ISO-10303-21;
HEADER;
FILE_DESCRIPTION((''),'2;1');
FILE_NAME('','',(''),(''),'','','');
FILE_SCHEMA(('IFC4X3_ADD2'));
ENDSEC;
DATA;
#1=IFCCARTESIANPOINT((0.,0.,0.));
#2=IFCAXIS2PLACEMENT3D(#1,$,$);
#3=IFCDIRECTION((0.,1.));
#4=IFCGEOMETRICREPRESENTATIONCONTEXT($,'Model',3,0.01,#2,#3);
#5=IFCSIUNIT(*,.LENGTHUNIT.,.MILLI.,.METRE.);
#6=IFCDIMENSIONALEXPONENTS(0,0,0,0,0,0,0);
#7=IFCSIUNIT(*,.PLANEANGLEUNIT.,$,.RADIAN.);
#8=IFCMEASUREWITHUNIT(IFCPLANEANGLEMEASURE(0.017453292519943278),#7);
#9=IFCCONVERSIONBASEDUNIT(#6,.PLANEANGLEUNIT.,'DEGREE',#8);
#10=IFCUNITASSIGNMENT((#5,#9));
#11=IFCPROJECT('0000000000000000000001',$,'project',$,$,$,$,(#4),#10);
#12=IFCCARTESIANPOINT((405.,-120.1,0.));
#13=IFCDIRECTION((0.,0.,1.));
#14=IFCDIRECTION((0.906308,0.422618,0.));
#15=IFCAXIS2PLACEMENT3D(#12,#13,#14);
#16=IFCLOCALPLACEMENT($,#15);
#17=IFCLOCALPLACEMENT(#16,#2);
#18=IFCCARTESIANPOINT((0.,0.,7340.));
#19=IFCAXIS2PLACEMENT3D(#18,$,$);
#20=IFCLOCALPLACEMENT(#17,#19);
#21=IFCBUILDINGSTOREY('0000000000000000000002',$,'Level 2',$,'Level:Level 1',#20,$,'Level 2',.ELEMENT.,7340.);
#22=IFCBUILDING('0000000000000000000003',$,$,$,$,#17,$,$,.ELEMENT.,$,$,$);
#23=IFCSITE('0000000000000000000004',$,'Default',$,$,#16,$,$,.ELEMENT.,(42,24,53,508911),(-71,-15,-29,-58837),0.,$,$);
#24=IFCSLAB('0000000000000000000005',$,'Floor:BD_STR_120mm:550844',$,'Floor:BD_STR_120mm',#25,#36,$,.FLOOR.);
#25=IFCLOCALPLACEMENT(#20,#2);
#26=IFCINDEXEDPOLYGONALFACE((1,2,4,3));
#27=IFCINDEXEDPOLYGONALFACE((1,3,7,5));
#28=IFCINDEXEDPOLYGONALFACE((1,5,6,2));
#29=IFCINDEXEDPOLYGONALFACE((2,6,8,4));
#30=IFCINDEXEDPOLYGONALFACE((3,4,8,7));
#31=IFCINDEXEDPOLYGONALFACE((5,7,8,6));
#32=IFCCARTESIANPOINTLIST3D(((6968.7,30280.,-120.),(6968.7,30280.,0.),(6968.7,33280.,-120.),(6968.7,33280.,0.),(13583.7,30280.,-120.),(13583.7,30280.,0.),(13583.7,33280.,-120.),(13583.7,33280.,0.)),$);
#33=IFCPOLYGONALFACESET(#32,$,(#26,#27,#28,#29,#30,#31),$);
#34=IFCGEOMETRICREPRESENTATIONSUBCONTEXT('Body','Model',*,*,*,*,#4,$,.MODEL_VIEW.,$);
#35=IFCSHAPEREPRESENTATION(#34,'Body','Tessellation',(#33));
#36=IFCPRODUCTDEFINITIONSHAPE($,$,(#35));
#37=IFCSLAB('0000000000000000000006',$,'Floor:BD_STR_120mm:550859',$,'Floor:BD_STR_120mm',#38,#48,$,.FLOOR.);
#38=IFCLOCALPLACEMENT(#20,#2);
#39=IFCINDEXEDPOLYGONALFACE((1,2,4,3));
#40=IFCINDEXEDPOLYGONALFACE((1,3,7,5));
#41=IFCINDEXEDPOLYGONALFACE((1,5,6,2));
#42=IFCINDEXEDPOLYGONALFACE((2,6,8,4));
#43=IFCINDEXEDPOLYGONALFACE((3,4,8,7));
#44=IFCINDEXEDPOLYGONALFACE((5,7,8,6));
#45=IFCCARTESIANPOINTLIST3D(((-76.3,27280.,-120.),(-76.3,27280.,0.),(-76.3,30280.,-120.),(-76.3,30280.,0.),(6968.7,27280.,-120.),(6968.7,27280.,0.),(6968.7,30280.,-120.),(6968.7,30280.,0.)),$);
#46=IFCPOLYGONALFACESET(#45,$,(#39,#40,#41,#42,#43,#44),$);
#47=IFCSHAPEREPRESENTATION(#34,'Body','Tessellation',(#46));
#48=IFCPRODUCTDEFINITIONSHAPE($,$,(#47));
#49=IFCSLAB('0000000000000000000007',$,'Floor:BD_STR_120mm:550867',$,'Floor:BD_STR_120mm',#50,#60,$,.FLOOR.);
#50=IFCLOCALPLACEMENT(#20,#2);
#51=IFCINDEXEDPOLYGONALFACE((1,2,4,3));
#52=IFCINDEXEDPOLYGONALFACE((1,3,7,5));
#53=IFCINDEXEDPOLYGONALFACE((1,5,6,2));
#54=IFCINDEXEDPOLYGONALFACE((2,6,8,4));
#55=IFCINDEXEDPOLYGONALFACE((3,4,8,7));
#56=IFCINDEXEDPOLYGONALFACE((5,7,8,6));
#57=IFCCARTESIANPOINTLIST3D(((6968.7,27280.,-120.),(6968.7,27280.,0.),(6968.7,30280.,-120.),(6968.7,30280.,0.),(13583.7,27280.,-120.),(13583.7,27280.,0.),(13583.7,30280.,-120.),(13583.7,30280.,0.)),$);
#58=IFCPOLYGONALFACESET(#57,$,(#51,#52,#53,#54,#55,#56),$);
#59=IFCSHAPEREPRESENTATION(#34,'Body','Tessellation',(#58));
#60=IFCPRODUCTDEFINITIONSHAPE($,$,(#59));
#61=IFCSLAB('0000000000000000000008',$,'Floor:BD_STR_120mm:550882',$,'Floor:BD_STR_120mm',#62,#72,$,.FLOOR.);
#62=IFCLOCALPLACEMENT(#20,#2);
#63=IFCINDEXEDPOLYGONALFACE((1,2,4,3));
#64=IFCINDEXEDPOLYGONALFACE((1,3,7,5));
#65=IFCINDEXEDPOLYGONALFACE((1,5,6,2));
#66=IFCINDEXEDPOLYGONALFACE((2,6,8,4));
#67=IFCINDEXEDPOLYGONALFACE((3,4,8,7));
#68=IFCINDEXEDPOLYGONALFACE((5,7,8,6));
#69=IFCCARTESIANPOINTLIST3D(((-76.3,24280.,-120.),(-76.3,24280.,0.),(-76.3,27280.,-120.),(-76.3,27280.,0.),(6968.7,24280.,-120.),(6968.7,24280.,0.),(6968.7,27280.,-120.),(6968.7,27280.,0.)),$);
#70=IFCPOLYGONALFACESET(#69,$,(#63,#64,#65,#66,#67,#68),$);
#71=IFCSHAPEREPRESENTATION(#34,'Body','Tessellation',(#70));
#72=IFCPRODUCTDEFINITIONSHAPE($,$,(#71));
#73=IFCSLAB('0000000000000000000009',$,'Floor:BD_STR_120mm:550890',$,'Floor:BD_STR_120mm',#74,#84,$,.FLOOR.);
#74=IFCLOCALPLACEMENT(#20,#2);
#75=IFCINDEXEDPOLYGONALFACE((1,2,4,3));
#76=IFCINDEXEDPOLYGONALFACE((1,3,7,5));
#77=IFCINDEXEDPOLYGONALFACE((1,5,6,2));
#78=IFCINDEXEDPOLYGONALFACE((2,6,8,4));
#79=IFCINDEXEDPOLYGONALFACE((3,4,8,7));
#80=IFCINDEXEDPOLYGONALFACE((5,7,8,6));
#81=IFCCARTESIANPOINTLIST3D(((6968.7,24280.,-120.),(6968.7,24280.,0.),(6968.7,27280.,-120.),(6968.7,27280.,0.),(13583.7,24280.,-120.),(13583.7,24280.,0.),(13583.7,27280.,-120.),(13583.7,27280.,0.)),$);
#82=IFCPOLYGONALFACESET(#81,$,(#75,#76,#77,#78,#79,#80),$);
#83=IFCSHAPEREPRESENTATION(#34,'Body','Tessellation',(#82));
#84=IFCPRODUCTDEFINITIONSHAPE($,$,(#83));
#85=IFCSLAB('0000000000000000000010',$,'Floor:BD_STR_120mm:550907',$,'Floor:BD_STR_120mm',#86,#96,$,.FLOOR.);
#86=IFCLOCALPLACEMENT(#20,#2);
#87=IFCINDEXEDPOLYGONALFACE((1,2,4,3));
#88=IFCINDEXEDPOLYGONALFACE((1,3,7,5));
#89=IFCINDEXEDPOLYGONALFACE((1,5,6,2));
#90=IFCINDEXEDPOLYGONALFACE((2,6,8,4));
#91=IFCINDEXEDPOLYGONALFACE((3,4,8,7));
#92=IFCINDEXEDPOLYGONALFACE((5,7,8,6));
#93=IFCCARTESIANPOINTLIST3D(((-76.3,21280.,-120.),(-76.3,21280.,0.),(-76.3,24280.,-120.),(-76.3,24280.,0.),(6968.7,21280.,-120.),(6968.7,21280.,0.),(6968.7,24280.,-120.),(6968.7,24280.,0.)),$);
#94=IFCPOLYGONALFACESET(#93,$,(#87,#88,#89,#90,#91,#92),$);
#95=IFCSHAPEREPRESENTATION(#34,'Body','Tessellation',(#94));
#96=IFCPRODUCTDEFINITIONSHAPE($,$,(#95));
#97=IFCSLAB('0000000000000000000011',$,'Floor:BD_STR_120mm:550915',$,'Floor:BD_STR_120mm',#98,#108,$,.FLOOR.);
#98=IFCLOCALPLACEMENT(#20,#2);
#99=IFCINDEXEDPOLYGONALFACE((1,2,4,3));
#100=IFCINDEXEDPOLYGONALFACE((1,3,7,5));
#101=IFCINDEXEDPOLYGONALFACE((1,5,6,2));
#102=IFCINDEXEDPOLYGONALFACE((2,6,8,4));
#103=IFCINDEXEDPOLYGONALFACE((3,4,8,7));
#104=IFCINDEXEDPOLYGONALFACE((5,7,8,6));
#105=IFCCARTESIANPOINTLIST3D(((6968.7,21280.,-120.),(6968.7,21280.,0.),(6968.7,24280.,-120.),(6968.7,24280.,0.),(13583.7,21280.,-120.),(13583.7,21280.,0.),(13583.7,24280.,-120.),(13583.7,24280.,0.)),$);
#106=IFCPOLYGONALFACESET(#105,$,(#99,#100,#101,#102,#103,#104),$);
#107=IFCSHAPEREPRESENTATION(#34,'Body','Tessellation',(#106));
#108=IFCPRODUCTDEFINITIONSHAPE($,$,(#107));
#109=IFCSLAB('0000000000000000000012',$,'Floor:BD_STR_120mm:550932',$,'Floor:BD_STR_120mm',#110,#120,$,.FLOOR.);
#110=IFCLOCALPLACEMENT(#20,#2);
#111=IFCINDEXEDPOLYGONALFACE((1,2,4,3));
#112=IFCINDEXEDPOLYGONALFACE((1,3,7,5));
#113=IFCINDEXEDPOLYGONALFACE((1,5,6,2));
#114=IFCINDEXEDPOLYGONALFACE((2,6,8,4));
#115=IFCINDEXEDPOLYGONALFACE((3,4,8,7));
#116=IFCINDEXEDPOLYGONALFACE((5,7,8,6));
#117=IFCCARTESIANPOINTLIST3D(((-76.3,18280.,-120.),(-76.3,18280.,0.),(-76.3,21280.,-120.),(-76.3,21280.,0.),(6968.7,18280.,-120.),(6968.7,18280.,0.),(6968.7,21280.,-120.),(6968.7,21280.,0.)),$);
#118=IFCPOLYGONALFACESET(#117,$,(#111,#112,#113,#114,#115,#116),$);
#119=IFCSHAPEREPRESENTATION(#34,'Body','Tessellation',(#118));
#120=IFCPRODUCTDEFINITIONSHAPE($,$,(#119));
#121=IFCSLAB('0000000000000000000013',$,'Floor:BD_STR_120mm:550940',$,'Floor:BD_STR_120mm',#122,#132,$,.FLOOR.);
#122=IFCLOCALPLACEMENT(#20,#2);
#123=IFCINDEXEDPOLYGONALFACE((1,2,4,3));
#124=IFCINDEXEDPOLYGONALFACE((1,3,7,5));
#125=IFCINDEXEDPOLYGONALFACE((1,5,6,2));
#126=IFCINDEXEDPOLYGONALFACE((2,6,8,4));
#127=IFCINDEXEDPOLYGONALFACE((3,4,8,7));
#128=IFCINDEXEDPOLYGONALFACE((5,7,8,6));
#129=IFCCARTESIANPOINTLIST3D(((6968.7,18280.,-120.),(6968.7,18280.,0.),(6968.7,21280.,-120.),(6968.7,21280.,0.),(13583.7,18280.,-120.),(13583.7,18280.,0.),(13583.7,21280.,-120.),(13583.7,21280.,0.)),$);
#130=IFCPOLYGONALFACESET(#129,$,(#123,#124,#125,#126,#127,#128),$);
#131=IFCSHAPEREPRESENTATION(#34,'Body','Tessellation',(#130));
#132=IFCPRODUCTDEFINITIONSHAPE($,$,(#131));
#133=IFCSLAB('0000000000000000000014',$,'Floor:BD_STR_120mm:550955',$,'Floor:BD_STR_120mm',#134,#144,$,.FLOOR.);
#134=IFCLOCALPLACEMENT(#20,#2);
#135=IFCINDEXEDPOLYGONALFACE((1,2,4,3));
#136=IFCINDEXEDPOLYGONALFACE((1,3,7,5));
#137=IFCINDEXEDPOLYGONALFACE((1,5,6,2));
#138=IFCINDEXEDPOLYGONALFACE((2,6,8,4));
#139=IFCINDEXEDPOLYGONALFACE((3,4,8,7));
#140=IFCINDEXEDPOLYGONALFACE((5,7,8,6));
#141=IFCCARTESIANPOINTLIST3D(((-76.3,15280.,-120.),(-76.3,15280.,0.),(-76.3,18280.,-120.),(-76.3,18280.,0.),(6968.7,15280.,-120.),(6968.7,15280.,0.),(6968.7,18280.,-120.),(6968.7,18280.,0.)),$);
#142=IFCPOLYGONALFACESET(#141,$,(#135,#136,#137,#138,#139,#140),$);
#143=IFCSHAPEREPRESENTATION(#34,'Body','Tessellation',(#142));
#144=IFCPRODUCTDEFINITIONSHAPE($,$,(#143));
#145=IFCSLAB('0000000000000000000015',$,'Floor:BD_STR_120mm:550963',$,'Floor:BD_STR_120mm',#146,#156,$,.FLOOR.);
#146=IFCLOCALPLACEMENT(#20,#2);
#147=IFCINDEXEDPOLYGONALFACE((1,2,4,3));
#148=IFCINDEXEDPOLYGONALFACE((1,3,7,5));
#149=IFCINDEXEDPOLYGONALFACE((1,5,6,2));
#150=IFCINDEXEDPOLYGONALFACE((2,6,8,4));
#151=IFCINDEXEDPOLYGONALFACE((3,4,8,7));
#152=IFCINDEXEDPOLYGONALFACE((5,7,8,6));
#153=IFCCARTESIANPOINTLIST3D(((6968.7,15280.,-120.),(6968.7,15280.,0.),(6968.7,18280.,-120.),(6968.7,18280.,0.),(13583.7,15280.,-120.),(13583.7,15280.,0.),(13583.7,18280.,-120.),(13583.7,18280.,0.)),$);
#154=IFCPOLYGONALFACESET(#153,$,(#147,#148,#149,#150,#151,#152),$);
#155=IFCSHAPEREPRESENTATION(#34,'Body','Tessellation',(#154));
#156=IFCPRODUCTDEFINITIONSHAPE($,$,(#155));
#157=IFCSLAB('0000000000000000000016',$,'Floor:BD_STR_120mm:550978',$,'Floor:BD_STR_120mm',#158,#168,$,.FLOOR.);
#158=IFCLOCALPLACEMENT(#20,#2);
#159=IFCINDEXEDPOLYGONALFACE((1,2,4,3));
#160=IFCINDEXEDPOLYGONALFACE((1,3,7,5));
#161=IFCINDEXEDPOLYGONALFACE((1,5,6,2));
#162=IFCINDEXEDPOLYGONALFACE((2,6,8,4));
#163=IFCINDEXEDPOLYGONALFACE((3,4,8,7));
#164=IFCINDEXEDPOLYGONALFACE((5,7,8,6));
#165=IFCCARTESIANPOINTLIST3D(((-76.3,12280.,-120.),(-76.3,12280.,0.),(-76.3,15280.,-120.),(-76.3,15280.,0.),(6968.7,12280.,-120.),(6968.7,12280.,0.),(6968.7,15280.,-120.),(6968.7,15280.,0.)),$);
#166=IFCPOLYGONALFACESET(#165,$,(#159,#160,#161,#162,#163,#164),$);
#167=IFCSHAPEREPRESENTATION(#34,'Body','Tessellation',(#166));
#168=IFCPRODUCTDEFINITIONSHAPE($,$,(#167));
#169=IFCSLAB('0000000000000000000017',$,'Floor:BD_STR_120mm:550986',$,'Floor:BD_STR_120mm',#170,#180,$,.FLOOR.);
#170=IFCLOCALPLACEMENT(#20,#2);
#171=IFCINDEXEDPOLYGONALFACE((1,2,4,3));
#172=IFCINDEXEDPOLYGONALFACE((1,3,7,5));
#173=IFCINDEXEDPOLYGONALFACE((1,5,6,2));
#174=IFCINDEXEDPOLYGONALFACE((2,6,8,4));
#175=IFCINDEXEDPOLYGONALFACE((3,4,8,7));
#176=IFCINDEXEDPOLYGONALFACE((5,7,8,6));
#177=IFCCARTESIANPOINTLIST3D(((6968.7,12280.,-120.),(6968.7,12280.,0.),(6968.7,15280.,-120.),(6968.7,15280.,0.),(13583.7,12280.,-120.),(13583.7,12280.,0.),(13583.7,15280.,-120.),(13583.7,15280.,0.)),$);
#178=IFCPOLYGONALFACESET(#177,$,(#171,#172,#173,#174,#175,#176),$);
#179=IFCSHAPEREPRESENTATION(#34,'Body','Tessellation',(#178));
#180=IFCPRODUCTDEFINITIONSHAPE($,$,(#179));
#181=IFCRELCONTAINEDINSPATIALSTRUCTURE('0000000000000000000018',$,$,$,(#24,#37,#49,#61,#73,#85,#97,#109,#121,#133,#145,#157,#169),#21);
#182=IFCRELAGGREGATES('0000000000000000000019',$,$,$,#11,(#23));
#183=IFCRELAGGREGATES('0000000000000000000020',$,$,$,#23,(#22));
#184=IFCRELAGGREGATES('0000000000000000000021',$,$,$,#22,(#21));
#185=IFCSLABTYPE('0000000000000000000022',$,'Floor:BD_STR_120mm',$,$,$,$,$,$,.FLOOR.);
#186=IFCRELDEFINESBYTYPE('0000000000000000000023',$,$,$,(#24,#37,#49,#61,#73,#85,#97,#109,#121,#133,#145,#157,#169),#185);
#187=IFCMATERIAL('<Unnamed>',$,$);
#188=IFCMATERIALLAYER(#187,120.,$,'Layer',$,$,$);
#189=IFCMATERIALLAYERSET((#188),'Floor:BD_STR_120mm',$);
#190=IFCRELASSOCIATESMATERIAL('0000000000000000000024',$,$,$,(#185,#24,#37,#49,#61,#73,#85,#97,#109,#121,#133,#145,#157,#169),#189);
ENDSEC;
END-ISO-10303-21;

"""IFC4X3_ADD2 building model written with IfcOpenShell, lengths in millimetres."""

from ifc_helpers import new_model, entity, si_unit, converted_unit, direction, frame, frame_2d, origin, origin_2d_with_axis, place, context, subcontext, project, spatial, rectangle, extrude, material, layer, layer_set, layer_usage, type_object, element, save


model = new_model("IFC4X3_ADD2")

# Units and contexts
model_context = context("Model", 3, precision=0.01, world=origin(), true_north=direction((0.0, 1.0)))
body_context = subcontext(model_context, "Body", "Model", "MODEL_VIEW")
ifc_project = project(units=[si_unit("LENGTHUNIT", "METRE", prefix="MILLI"), converted_unit("PLANEANGLEUNIT", "DEGREE", entity("IfcPlaneAngleMeasure", 0.017453292519943278), si_unit("PLANEANGLEUNIT", "RADIAN"), dimensions=[0, 0, 0, 0, 0, 0, 0])], contexts=[model_context])

# Site, building, storey
site_placement = place(None, frame((405.0, -120.1, 0.0), z_axis=(0.0, 0.0, 1.0), x_axis=(0.906308, 0.422618, 0.0)))
site = spatial("IfcSite", under=ifc_project, at=site_placement, Name="Default", CompositionType="ELEMENT", RefLatitude=(42, 24, 53, 508911), RefLongitude=(-71, -15, -29, -58837), RefElevation=0.0)
building_placement = place(site_placement, origin())
building = spatial("IfcBuilding", under=site, at=building_placement, CompositionType="ELEMENT")
storey_placement = place(building_placement, frame((0.0, 0.0, 7340.0)))
storey = spatial("IfcBuildingStorey", under=building, at=storey_placement, Name="Level 2", ObjectType="Level:Level 1", LongName="Level 2", CompositionType="ELEMENT", Elevation=7340.0)

# Slabs
ifc_material = material(Name="<Unnamed>")
ifc_layer = layer(ifc_material, 120.0, Name="Layer")
ifc_layer_set = layer_set([ifc_layer], Name="Floor:BD_STR_120mm")
slab_type = type_object("IfcSlabType", Name="Floor:BD_STR_120mm", PredefinedType="FLOOR", material=ifc_layer_set)
ifc_layer_usage_1 = layer_usage(ifc_layer_set, "AXIS3", "POSITIVE", 0.0)
slab_1_placement = place(storey_placement, origin())
element("IfcSlab", 1, at=slab_1_placement, inside=storey, type_object=slab_type, material=ifc_layer_usage_1, Name="Floor:BD_STR_120mm:550844", ObjectType="Floor:BD_STR_120mm", PredefinedType="FLOOR", context=body_context, shape_type="SweptSolid", body=[
    extrude(rectangle(XDim=3000.0, YDim=6615.0, at=frame_2d((0.0, 0.0), x_axis=(1.0, 0.0))), frame((10276.2, 31780.0, 0.0), z_axis=(0.0, 0.0, -1.0), x_axis=(0.0, 1.0, 0.0)), (0.0, 0.0, 1.0), 120.0),
])
ifc_layer_usage_2 = layer_usage(ifc_layer_set, "AXIS3", "POSITIVE", 0.0)
slab_2_placement = place(storey_placement, origin())
element("IfcSlab", 2, at=slab_2_placement, inside=storey, type_object=slab_type, material=ifc_layer_usage_2, Name="Floor:BD_STR_120mm:550859", ObjectType="Floor:BD_STR_120mm", PredefinedType="FLOOR", context=body_context, shape_type="SweptSolid", body=[
    extrude(rectangle(XDim=3000.0, YDim=7045.0, at=origin_2d_with_axis()), frame((3446.2, 28780.0, 0.0), z_axis=(0.0, 0.0, -1.0), x_axis=(0.0, 1.0, 0.0)), (0.0, 0.0, 1.0), 120.0),
])
ifc_layer_usage_3 = layer_usage(ifc_layer_set, "AXIS3", "POSITIVE", 0.0)
slab_3_placement = place(storey_placement, origin())
element("IfcSlab", 3, at=slab_3_placement, inside=storey, type_object=slab_type, material=ifc_layer_usage_3, Name="Floor:BD_STR_120mm:550867", ObjectType="Floor:BD_STR_120mm", PredefinedType="FLOOR", context=body_context, shape_type="SweptSolid", body=[
    extrude(rectangle(XDim=3000.0, YDim=6615.0, at=frame_2d((0.0, 0.0), x_axis=(1.0, 0.0))), frame((10276.2, 28780.0, 0.0), z_axis=(0.0, 0.0, -1.0), x_axis=(0.0, 1.0, 0.0)), (0.0, 0.0, 1.0), 120.0),
])
ifc_layer_usage_4 = layer_usage(ifc_layer_set, "AXIS3", "POSITIVE", 0.0)
slab_4_placement = place(storey_placement, origin())
element("IfcSlab", 4, at=slab_4_placement, inside=storey, type_object=slab_type, material=ifc_layer_usage_4, Name="Floor:BD_STR_120mm:550882", ObjectType="Floor:BD_STR_120mm", PredefinedType="FLOOR", context=body_context, shape_type="SweptSolid", body=[
    extrude(rectangle(XDim=3000.0, YDim=7045.0, at=origin_2d_with_axis()), frame((3446.2, 25780.0, 0.0), z_axis=(0.0, 0.0, -1.0), x_axis=(0.0, 1.0, 0.0)), (0.0, 0.0, 1.0), 120.0),
])
ifc_layer_usage_5 = layer_usage(ifc_layer_set, "AXIS3", "POSITIVE", 0.0)
slab_5_placement = place(storey_placement, origin())
element("IfcSlab", 5, at=slab_5_placement, inside=storey, type_object=slab_type, material=ifc_layer_usage_5, Name="Floor:BD_STR_120mm:550890", ObjectType="Floor:BD_STR_120mm", PredefinedType="FLOOR", context=body_context, shape_type="SweptSolid", body=[
    extrude(rectangle(XDim=3000.0, YDim=6615.0, at=frame_2d((0.0, 0.0), x_axis=(1.0, 0.0))), frame((10276.2, 25780.0, 0.0), z_axis=(0.0, 0.0, -1.0), x_axis=(0.0, 1.0, 0.0)), (0.0, 0.0, 1.0), 120.0),
])
ifc_layer_usage_6 = layer_usage(ifc_layer_set, "AXIS3", "POSITIVE", 0.0)
slab_6_placement = place(storey_placement, origin())
element("IfcSlab", 6, at=slab_6_placement, inside=storey, type_object=slab_type, material=ifc_layer_usage_6, Name="Floor:BD_STR_120mm:550907", ObjectType="Floor:BD_STR_120mm", PredefinedType="FLOOR", context=body_context, shape_type="SweptSolid", body=[
    extrude(rectangle(XDim=3000.0, YDim=7045.0, at=origin_2d_with_axis()), frame((3446.2, 22780.0, 0.0), z_axis=(0.0, 0.0, -1.0), x_axis=(0.0, 1.0, 0.0)), (0.0, 0.0, 1.0), 120.0),
])
ifc_layer_usage_7 = layer_usage(ifc_layer_set, "AXIS3", "POSITIVE", 0.0)
slab_7_placement = place(storey_placement, origin())
element("IfcSlab", 7, at=slab_7_placement, inside=storey, type_object=slab_type, material=ifc_layer_usage_7, Name="Floor:BD_STR_120mm:550915", ObjectType="Floor:BD_STR_120mm", PredefinedType="FLOOR", context=body_context, shape_type="SweptSolid", body=[
    extrude(rectangle(XDim=3000.0, YDim=6615.0, at=frame_2d((0.0, 0.0), x_axis=(1.0, 0.0))), frame((10276.2, 22780.0, 0.0), z_axis=(0.0, 0.0, -1.0), x_axis=(0.0, 1.0, 0.0)), (0.0, 0.0, 1.0), 120.0),
])
ifc_layer_usage_8 = layer_usage(ifc_layer_set, "AXIS3", "POSITIVE", 0.0)
slab_8_placement = place(storey_placement, origin())
element("IfcSlab", 8, at=slab_8_placement, inside=storey, type_object=slab_type, material=ifc_layer_usage_8, Name="Floor:BD_STR_120mm:550932", ObjectType="Floor:BD_STR_120mm", PredefinedType="FLOOR", context=body_context, shape_type="SweptSolid", body=[
    extrude(rectangle(XDim=3000.0, YDim=7045.0, at=origin_2d_with_axis()), frame((3446.2, 19780.0, 0.0), z_axis=(0.0, 0.0, -1.0), x_axis=(0.0, 1.0, 0.0)), (0.0, 0.0, 1.0), 120.0),
])
ifc_layer_usage_9 = layer_usage(ifc_layer_set, "AXIS3", "POSITIVE", 0.0)
slab_9_placement = place(storey_placement, origin())
element("IfcSlab", 9, at=slab_9_placement, inside=storey, type_object=slab_type, material=ifc_layer_usage_9, Name="Floor:BD_STR_120mm:550940", ObjectType="Floor:BD_STR_120mm", PredefinedType="FLOOR", context=body_context, shape_type="SweptSolid", body=[
    extrude(rectangle(XDim=3000.0, YDim=6615.0, at=frame_2d((0.0, 0.0), x_axis=(1.0, 0.0))), frame((10276.2, 19780.0, 0.0), z_axis=(0.0, 0.0, -1.0), x_axis=(0.0, 1.0, 0.0)), (0.0, 0.0, 1.0), 120.0),
])
ifc_layer_usage_10 = layer_usage(ifc_layer_set, "AXIS3", "POSITIVE", 0.0)
slab_10_placement = place(storey_placement, origin())
element("IfcSlab", 10, at=slab_10_placement, inside=storey, type_object=slab_type, material=ifc_layer_usage_10, Name="Floor:BD_STR_120mm:550955", ObjectType="Floor:BD_STR_120mm", PredefinedType="FLOOR", context=body_context, shape_type="SweptSolid", body=[
    extrude(rectangle(XDim=3000.0, YDim=7045.0, at=origin_2d_with_axis()), frame((3446.2, 16780.0, 0.0), z_axis=(0.0, 0.0, -1.0), x_axis=(0.0, 1.0, 0.0)), (0.0, 0.0, 1.0), 120.0),
])
ifc_layer_usage_11 = layer_usage(ifc_layer_set, "AXIS3", "POSITIVE", 0.0)
slab_11_placement = place(storey_placement, origin())
element("IfcSlab", 11, at=slab_11_placement, inside=storey, type_object=slab_type, material=ifc_layer_usage_11, Name="Floor:BD_STR_120mm:550963", ObjectType="Floor:BD_STR_120mm", PredefinedType="FLOOR", context=body_context, shape_type="SweptSolid", body=[
    extrude(rectangle(XDim=3000.0, YDim=6615.0, at=frame_2d((0.0, 0.0), x_axis=(1.0, 0.0))), frame((10276.2, 16780.0, 0.0), z_axis=(0.0, 0.0, -1.0), x_axis=(0.0, 1.0, 0.0)), (0.0, 0.0, 1.0), 120.0),
])
ifc_layer_usage_12 = layer_usage(ifc_layer_set, "AXIS3", "POSITIVE", 0.0)
slab_12_placement = place(storey_placement, origin())
element("IfcSlab", 12, at=slab_12_placement, inside=storey, type_object=slab_type, material=ifc_layer_usage_12, Name="Floor:BD_STR_120mm:550978", ObjectType="Floor:BD_STR_120mm", PredefinedType="FLOOR", context=body_context, shape_type="SweptSolid", body=[
    extrude(rectangle(XDim=3000.0, YDim=7045.0, at=origin_2d_with_axis()), frame((3446.2, 13780.0, 0.0), z_axis=(0.0, 0.0, -1.0), x_axis=(0.0, 1.0, 0.0)), (0.0, 0.0, 1.0), 120.0),
])
ifc_layer_usage_13 = layer_usage(ifc_layer_set, "AXIS3", "POSITIVE", 0.0)
slab_13_placement = place(storey_placement, origin())
element("IfcSlab", 13, at=slab_13_placement, inside=storey, type_object=slab_type, material=ifc_layer_usage_13, Name="Floor:BD_STR_120mm:550986", ObjectType="Floor:BD_STR_120mm", PredefinedType="FLOOR", context=body_context, shape_type="SweptSolid", body=[
    extrude(rectangle(XDim=3000.0, YDim=6615.0, at=frame_2d((0.0, 0.0), x_axis=(1.0, 0.0))), frame((10276.2, 13780.0, 0.0), z_axis=(0.0, 0.0, -1.0), x_axis=(0.0, 1.0, 0.0)), (0.0, 0.0, 1.0), 120.0),
])

save(model, "model.ifc")
